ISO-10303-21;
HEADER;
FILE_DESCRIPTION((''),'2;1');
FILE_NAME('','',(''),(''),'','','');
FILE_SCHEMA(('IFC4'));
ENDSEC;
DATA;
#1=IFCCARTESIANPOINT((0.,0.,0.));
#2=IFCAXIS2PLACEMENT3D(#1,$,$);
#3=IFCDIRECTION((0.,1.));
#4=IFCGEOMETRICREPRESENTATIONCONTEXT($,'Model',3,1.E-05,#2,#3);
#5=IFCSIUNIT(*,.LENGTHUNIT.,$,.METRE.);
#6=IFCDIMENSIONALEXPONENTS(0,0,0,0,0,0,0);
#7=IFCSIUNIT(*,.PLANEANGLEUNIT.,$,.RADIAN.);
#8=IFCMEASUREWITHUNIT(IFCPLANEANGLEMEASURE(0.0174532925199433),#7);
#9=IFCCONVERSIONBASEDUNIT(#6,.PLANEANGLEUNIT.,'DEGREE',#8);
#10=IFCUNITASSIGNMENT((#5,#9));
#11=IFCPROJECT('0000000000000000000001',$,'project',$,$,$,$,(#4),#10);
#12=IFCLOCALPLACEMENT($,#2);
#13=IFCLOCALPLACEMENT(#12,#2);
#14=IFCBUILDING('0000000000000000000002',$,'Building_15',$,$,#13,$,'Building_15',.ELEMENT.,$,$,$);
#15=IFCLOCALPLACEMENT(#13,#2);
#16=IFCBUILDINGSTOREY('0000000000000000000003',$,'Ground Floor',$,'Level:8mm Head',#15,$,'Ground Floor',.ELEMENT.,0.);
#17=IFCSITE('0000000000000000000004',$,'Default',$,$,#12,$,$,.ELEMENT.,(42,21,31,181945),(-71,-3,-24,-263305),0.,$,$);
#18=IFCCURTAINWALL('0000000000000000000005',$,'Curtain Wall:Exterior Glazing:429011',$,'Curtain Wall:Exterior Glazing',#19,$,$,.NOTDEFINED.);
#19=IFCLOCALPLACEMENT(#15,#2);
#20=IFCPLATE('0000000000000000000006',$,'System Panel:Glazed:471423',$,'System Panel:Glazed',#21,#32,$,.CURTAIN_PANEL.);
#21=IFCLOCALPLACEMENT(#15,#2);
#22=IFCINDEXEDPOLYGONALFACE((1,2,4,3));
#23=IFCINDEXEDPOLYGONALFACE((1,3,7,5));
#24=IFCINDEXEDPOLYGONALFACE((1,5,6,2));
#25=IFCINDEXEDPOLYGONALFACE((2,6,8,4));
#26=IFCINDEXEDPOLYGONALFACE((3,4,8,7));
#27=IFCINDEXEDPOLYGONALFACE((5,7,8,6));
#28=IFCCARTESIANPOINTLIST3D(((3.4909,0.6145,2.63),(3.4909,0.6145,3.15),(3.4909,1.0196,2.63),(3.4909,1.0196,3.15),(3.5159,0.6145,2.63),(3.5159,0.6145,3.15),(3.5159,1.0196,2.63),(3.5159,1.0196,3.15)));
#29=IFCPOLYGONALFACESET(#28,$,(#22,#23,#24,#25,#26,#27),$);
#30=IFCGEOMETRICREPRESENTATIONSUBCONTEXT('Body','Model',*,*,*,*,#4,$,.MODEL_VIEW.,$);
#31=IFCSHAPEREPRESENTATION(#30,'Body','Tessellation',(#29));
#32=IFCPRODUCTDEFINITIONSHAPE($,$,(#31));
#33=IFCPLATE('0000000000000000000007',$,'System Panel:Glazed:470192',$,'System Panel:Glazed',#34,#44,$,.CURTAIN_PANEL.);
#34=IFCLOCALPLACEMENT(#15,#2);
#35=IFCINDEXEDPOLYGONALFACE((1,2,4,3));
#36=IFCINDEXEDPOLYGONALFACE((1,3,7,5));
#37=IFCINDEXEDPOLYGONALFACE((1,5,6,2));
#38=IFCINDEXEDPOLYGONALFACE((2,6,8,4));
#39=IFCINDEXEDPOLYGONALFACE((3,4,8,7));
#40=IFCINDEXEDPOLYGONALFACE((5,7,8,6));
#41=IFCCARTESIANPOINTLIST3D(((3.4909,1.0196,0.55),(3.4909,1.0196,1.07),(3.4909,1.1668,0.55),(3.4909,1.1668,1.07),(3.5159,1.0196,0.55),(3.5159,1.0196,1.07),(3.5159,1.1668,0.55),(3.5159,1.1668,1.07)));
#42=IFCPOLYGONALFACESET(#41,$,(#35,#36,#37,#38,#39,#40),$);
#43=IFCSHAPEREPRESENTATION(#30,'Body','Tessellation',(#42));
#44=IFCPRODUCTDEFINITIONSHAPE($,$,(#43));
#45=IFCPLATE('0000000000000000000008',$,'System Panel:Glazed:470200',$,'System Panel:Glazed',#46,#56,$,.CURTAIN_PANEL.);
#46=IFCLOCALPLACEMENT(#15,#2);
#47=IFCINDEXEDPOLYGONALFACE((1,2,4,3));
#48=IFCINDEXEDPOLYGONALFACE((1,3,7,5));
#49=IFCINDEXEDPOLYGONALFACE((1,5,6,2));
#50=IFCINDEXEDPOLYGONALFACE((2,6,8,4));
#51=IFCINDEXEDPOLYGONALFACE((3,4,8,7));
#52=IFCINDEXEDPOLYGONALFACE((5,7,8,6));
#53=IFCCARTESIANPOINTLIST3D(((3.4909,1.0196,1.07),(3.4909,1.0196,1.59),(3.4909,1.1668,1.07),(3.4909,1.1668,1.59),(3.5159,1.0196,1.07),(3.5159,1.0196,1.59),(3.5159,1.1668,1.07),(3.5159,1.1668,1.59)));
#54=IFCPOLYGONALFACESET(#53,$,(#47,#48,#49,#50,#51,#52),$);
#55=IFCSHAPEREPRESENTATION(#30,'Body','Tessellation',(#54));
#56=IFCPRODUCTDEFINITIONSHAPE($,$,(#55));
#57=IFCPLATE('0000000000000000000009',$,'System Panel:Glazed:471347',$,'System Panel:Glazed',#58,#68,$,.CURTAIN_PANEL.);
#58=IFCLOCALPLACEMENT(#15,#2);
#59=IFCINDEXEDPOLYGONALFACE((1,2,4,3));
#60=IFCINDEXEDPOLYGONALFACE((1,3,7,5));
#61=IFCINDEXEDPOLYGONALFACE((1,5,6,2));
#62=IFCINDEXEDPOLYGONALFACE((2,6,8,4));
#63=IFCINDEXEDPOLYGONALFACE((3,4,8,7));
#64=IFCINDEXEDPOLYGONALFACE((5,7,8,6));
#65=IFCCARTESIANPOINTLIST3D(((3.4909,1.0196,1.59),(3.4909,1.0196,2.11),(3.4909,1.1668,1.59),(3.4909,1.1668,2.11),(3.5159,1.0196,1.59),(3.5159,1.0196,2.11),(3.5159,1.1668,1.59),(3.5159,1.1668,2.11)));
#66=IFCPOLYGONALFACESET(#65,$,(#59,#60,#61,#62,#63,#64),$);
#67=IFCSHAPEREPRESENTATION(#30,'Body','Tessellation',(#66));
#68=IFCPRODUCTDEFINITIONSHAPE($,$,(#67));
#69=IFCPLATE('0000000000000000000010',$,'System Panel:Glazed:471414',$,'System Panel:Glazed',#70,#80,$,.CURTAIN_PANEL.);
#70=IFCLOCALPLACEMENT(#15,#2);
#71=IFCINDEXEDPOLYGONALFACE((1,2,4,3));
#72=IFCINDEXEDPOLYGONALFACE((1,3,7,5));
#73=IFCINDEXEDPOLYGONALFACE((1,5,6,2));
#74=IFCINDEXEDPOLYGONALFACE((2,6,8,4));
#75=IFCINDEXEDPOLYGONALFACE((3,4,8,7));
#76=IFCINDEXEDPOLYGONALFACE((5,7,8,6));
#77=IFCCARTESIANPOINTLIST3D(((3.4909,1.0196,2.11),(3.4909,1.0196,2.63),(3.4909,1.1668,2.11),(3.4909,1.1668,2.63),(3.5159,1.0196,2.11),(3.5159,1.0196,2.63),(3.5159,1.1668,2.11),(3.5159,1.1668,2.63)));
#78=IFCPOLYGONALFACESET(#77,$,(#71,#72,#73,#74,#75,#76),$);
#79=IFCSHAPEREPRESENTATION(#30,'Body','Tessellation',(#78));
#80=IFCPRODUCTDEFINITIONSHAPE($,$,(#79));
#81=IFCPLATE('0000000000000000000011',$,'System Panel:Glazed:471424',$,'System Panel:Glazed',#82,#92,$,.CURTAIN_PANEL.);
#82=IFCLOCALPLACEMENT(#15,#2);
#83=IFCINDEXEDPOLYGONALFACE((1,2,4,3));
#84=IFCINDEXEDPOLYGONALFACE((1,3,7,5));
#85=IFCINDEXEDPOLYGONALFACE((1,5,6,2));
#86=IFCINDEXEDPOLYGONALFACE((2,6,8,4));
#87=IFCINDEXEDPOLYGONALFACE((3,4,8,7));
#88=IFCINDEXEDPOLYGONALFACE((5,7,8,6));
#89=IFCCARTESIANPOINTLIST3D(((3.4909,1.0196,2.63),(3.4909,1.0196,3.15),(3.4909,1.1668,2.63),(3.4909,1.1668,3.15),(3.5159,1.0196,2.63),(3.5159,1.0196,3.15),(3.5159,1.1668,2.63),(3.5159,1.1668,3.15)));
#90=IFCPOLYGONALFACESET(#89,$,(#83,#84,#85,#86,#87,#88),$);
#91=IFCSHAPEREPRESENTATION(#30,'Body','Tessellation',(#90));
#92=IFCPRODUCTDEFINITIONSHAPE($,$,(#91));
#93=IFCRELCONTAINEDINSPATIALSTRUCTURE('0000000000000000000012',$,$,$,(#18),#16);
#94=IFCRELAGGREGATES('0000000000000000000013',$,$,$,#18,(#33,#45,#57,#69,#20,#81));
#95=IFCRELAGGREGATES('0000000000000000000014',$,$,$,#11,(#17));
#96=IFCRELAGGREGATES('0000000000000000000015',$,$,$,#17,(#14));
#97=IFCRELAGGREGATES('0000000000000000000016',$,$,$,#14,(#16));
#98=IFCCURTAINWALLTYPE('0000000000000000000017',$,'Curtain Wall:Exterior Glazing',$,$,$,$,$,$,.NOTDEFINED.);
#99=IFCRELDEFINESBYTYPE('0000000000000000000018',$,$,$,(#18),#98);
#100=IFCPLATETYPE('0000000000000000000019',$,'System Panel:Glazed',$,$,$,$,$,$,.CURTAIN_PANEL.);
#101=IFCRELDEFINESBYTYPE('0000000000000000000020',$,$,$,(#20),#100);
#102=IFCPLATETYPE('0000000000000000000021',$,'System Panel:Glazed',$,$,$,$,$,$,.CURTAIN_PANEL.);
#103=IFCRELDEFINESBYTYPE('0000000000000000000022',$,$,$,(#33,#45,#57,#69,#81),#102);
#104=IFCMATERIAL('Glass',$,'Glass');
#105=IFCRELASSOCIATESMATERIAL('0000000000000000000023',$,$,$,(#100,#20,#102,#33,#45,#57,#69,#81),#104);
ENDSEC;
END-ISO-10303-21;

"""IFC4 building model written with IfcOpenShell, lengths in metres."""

from ifc_helpers import new_model, entity, si_unit, converted_unit, direction, frame, origin, place, context, subcontext, project, spatial, indexed_curve, outline, extrude, source, transform, mapped, material, type_object, type_shapes, element, aggregate, save


model = new_model("IFC4")

# Units and contexts
model_context = context("Model", 3, precision=1e-05, world=origin(), true_north=direction((0.0, 1.0)))
body_context = subcontext(model_context, "Body", "Model", "MODEL_VIEW")
ifc_project = project(units=[si_unit("LENGTHUNIT", "METRE"), converted_unit("PLANEANGLEUNIT", "DEGREE", entity("IfcPlaneAngleMeasure", 0.0174532925199433), si_unit("PLANEANGLEUNIT", "RADIAN"), dimensions=[0, 0, 0, 0, 0, 0, 0])], contexts=[model_context])

# Site, building, storey
site_placement = place(None, origin())
site = spatial("IfcSite", under=ifc_project, at=site_placement, Name="Default", CompositionType="ELEMENT", RefLatitude=(42, 21, 31, 181945), RefLongitude=(-71, -3, -24, -263305), RefElevation=0.0)
building_placement = place(site_placement, origin())
building = spatial("IfcBuilding", under=site, at=building_placement, Name="Building_15", LongName="Building_15", CompositionType="ELEMENT")
storey_placement = place(building_placement, origin())
storey = spatial("IfcBuildingStorey", under=building, at=storey_placement, Name="Ground Floor", ObjectType="Level:8mm Head", LongName="Ground Floor", CompositionType="ELEMENT", Elevation=0.0)

# Curtain wall, plates
curtain_wall_type = type_object("IfcCurtainWallType", Name="Curtain Wall:Exterior Glazing", PredefinedType="NOTDEFINED")
curtain_wall_placement = place(storey_placement, origin())
curtain_wall = element("IfcCurtainWall", 1, at=curtain_wall_placement, inside=storey, type_object=curtain_wall_type, Name="Curtain Wall:Exterior Glazing:429011", ObjectType="Curtain Wall:Exterior Glazing", PredefinedType="NOTDEFINED")
ifc_material_1 = material(Name="Glass", Category="Glass")
plate_type_1 = type_object("IfcPlateType", Name="System Panel:Glazed", PredefinedType="CURTAIN_PANEL", material=ifc_material_1)
shared_shape_1 = source(origin(), body_context, "Body", "SweptSolid", [
    extrude(outline(indexed_curve([(-0.0125, -0.2025), (0.0125, -0.2025), (0.0125, 0.2025), (-0.0125, 0.2025), (-0.0125, -0.2025)], self_intersect=False)), frame((0.0, 0.037, 0.0), z_axis=(0.0, 0.0, 1.0), x_axis=(0.0, 1.0, 0.0)), (0.0, 0.0, 1.0), 0.52),
])
type_shapes(plate_type_1, [shared_shape_1])
plate_1_placement = place(curtain_wall_placement, frame((3.5404, 0.8171, 2.63), z_axis=(0.0, 0.0, 1.0), x_axis=(0.0, 1.0, 0.0)))
plate_1 = element("IfcPlate", 2, at=plate_1_placement, type_object=plate_type_1, material=ifc_material_1, Name="System Panel:Glazed:471423", ObjectType="System Panel:Glazed", PredefinedType="CURTAIN_PANEL", context=body_context, shape_type="MappedRepresentation", body=[
    mapped(shared_shape_1, transform((0.0, 0.0, 0.0), scale=1.0)),
])
plate_type_2 = type_object("IfcPlateType", Name="System Panel:Glazed", PredefinedType="CURTAIN_PANEL", material=ifc_material_1)
shared_shape_2 = source(origin(), body_context, "Body", "SweptSolid", [
    extrude(outline(indexed_curve([(-0.0125, -0.0736), (0.0125, -0.0736), (0.0125, 0.0736), (-0.0125, 0.0736), (-0.0125, -0.0736)], self_intersect=False)), frame((0.0, 0.037, 0.0), z_axis=(0.0, 0.0, 1.0), x_axis=(0.0, 1.0, 0.0)), (0.0, 0.0, 1.0), 0.52),
])
type_shapes(plate_type_2, [shared_shape_2])
plate_2_placement = place(curtain_wall_placement, frame((3.5404, 1.0932, 0.55), z_axis=(0.0, 0.0, 1.0), x_axis=(0.0, 1.0, 0.0)))
plate_2 = element("IfcPlate", 3, at=plate_2_placement, type_object=plate_type_2, material=ifc_material_1, Name="System Panel:Glazed:470192", ObjectType="System Panel:Glazed", PredefinedType="CURTAIN_PANEL", context=body_context, shape_type="MappedRepresentation", body=[
    mapped(shared_shape_2, transform((0.0, 0.0, 0.0), scale=1.0)),
])
plate_3_placement = place(curtain_wall_placement, frame((3.5404, 1.0932, 1.07), z_axis=(0.0, 0.0, 1.0), x_axis=(0.0, 1.0, 0.0)))
plate_3 = element("IfcPlate", 4, at=plate_3_placement, type_object=plate_type_2, material=ifc_material_1, Name="System Panel:Glazed:470200", ObjectType="System Panel:Glazed", PredefinedType="CURTAIN_PANEL", context=body_context, shape_type="MappedRepresentation", body=[
    mapped(shared_shape_2, transform((0.0, 0.0, 0.0), scale=1.0)),
])
plate_4_placement = place(curtain_wall_placement, frame((3.5404, 1.0932, 1.59), z_axis=(0.0, 0.0, 1.0), x_axis=(0.0, 1.0, 0.0)))
plate_4 = element("IfcPlate", 5, at=plate_4_placement, type_object=plate_type_2, material=ifc_material_1, Name="System Panel:Glazed:471347", ObjectType="System Panel:Glazed", PredefinedType="CURTAIN_PANEL", context=body_context, shape_type="MappedRepresentation", body=[
    mapped(shared_shape_2, transform((0.0, 0.0, 0.0), scale=1.0)),
])
plate_5_placement = place(curtain_wall_placement, frame((3.5404, 1.0932, 2.11), z_axis=(0.0, 0.0, 1.0), x_axis=(0.0, 1.0, 0.0)))
plate_5 = element("IfcPlate", 6, at=plate_5_placement, type_object=plate_type_2, material=ifc_material_1, Name="System Panel:Glazed:471414", ObjectType="System Panel:Glazed", PredefinedType="CURTAIN_PANEL", context=body_context, shape_type="MappedRepresentation", body=[
    mapped(shared_shape_2, transform((0.0, 0.0, 0.0), scale=1.0)),
])
plate_6_placement = place(curtain_wall_placement, frame((3.5404, 1.0932, 2.63), z_axis=(0.0, 0.0, 1.0), x_axis=(0.0, 1.0, 0.0)))
plate_6 = element("IfcPlate", 7, at=plate_6_placement, type_object=plate_type_2, material=ifc_material_1, Name="System Panel:Glazed:471424", ObjectType="System Panel:Glazed", PredefinedType="CURTAIN_PANEL", context=body_context, shape_type="MappedRepresentation", body=[
    mapped(shared_shape_2, transform((0.0, 0.0, 0.0), scale=1.0)),
])
aggregate(curtain_wall, [plate_2, plate_3, plate_4, plate_5, plate_1, plate_6])

save(model, "model.ifc")
